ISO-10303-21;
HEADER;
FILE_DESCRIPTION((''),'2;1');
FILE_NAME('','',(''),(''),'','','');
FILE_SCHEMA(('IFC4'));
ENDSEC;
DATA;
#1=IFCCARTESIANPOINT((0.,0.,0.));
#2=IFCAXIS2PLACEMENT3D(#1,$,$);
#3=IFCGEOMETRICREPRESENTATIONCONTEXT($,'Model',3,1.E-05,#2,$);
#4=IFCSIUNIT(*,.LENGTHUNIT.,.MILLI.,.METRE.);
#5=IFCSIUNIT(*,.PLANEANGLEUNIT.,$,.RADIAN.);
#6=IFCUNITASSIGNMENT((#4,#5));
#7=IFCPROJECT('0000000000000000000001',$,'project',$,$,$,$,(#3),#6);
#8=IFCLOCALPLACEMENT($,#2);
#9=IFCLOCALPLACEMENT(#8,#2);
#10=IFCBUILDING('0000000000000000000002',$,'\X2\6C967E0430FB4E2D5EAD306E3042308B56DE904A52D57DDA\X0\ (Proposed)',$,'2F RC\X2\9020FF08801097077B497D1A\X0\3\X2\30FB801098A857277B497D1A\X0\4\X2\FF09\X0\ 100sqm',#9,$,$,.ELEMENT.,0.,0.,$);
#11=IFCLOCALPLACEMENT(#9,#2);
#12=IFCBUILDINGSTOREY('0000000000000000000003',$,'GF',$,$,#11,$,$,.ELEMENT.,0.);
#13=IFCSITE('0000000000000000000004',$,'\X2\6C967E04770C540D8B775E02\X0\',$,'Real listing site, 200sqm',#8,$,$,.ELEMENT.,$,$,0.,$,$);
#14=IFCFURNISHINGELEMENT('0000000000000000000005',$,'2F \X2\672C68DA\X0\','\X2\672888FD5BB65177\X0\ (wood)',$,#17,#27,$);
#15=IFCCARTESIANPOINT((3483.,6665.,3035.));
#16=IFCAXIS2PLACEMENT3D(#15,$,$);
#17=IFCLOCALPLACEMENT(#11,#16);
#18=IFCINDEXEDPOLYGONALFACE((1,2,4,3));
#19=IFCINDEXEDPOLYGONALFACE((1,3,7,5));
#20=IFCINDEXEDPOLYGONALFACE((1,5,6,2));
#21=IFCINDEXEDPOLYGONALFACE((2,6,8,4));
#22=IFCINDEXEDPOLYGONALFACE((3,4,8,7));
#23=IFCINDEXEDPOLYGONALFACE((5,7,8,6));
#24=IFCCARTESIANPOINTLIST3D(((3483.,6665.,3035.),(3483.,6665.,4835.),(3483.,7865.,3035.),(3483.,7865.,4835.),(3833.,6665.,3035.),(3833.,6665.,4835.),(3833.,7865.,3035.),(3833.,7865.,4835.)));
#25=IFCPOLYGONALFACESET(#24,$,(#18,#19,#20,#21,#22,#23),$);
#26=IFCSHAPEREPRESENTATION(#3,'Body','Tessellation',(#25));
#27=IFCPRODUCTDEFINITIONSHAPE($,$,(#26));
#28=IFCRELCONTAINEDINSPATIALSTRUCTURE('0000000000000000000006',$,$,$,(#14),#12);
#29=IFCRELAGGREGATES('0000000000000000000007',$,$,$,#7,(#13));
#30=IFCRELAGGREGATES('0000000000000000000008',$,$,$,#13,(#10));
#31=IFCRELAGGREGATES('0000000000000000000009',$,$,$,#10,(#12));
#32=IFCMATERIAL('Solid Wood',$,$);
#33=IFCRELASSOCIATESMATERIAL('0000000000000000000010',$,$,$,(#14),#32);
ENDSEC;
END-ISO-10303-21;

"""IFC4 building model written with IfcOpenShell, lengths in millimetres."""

from ifc_helpers import new_model, si_unit, frame, frame_2d, origin, place, context, project, spatial, rectangle, extrude, material, element, save


model = new_model("IFC4")

# Units and contexts
model_context = context("Model", 3, precision=1e-05, world=origin())
ifc_project = project(units=[si_unit("LENGTHUNIT", "METRE", prefix="MILLI"), si_unit("PLANEANGLEUNIT", "RADIAN")], contexts=[model_context])

# Site, building, storey
site_placement = place(None, origin())
site = spatial("IfcSite", under=ifc_project, at=site_placement, Name="沖縄県名護市", ObjectType="Real listing site, 200sqm", CompositionType="ELEMENT", RefElevation=0.0)
building_placement = place(site_placement, origin())
building = spatial("IfcBuilding", under=site, at=building_placement, Name="沖縄・中庭のある回遊動線 (Proposed)", ObjectType="2F RC造（耐震等級3・耐風圧等級4） 100sqm", CompositionType="ELEMENT", ElevationOfRefHeight=0.0, ElevationOfTerrain=0.0)
storey_placement = place(building_placement, origin())
storey = spatial("IfcBuildingStorey", under=building, at=storey_placement, Name="GF", CompositionType="ELEMENT", Elevation=0.0)

# Shared definitions
ifc_material_1 = material(Name="Solid Wood")

# Furnishing element
furnishing_placement = place(storey_placement, frame((3483.0, 6665.0, 3035.0)))
element("IfcFurnishingElement", 1, at=furnishing_placement, inside=storey, material=ifc_material_1, Name="2F 本棚", Description="木製家具 (wood)", context=model_context, shape_type="SweptSolid", body=[
    extrude(rectangle(XDim=350.0, YDim=1200.0, at=frame_2d((175.0, 600.0))), frame((3483.0, 6665.0, 3035.0)), (0.0, 0.0, 1.0), 1800.0),
])

save(model, "model.ifc")
